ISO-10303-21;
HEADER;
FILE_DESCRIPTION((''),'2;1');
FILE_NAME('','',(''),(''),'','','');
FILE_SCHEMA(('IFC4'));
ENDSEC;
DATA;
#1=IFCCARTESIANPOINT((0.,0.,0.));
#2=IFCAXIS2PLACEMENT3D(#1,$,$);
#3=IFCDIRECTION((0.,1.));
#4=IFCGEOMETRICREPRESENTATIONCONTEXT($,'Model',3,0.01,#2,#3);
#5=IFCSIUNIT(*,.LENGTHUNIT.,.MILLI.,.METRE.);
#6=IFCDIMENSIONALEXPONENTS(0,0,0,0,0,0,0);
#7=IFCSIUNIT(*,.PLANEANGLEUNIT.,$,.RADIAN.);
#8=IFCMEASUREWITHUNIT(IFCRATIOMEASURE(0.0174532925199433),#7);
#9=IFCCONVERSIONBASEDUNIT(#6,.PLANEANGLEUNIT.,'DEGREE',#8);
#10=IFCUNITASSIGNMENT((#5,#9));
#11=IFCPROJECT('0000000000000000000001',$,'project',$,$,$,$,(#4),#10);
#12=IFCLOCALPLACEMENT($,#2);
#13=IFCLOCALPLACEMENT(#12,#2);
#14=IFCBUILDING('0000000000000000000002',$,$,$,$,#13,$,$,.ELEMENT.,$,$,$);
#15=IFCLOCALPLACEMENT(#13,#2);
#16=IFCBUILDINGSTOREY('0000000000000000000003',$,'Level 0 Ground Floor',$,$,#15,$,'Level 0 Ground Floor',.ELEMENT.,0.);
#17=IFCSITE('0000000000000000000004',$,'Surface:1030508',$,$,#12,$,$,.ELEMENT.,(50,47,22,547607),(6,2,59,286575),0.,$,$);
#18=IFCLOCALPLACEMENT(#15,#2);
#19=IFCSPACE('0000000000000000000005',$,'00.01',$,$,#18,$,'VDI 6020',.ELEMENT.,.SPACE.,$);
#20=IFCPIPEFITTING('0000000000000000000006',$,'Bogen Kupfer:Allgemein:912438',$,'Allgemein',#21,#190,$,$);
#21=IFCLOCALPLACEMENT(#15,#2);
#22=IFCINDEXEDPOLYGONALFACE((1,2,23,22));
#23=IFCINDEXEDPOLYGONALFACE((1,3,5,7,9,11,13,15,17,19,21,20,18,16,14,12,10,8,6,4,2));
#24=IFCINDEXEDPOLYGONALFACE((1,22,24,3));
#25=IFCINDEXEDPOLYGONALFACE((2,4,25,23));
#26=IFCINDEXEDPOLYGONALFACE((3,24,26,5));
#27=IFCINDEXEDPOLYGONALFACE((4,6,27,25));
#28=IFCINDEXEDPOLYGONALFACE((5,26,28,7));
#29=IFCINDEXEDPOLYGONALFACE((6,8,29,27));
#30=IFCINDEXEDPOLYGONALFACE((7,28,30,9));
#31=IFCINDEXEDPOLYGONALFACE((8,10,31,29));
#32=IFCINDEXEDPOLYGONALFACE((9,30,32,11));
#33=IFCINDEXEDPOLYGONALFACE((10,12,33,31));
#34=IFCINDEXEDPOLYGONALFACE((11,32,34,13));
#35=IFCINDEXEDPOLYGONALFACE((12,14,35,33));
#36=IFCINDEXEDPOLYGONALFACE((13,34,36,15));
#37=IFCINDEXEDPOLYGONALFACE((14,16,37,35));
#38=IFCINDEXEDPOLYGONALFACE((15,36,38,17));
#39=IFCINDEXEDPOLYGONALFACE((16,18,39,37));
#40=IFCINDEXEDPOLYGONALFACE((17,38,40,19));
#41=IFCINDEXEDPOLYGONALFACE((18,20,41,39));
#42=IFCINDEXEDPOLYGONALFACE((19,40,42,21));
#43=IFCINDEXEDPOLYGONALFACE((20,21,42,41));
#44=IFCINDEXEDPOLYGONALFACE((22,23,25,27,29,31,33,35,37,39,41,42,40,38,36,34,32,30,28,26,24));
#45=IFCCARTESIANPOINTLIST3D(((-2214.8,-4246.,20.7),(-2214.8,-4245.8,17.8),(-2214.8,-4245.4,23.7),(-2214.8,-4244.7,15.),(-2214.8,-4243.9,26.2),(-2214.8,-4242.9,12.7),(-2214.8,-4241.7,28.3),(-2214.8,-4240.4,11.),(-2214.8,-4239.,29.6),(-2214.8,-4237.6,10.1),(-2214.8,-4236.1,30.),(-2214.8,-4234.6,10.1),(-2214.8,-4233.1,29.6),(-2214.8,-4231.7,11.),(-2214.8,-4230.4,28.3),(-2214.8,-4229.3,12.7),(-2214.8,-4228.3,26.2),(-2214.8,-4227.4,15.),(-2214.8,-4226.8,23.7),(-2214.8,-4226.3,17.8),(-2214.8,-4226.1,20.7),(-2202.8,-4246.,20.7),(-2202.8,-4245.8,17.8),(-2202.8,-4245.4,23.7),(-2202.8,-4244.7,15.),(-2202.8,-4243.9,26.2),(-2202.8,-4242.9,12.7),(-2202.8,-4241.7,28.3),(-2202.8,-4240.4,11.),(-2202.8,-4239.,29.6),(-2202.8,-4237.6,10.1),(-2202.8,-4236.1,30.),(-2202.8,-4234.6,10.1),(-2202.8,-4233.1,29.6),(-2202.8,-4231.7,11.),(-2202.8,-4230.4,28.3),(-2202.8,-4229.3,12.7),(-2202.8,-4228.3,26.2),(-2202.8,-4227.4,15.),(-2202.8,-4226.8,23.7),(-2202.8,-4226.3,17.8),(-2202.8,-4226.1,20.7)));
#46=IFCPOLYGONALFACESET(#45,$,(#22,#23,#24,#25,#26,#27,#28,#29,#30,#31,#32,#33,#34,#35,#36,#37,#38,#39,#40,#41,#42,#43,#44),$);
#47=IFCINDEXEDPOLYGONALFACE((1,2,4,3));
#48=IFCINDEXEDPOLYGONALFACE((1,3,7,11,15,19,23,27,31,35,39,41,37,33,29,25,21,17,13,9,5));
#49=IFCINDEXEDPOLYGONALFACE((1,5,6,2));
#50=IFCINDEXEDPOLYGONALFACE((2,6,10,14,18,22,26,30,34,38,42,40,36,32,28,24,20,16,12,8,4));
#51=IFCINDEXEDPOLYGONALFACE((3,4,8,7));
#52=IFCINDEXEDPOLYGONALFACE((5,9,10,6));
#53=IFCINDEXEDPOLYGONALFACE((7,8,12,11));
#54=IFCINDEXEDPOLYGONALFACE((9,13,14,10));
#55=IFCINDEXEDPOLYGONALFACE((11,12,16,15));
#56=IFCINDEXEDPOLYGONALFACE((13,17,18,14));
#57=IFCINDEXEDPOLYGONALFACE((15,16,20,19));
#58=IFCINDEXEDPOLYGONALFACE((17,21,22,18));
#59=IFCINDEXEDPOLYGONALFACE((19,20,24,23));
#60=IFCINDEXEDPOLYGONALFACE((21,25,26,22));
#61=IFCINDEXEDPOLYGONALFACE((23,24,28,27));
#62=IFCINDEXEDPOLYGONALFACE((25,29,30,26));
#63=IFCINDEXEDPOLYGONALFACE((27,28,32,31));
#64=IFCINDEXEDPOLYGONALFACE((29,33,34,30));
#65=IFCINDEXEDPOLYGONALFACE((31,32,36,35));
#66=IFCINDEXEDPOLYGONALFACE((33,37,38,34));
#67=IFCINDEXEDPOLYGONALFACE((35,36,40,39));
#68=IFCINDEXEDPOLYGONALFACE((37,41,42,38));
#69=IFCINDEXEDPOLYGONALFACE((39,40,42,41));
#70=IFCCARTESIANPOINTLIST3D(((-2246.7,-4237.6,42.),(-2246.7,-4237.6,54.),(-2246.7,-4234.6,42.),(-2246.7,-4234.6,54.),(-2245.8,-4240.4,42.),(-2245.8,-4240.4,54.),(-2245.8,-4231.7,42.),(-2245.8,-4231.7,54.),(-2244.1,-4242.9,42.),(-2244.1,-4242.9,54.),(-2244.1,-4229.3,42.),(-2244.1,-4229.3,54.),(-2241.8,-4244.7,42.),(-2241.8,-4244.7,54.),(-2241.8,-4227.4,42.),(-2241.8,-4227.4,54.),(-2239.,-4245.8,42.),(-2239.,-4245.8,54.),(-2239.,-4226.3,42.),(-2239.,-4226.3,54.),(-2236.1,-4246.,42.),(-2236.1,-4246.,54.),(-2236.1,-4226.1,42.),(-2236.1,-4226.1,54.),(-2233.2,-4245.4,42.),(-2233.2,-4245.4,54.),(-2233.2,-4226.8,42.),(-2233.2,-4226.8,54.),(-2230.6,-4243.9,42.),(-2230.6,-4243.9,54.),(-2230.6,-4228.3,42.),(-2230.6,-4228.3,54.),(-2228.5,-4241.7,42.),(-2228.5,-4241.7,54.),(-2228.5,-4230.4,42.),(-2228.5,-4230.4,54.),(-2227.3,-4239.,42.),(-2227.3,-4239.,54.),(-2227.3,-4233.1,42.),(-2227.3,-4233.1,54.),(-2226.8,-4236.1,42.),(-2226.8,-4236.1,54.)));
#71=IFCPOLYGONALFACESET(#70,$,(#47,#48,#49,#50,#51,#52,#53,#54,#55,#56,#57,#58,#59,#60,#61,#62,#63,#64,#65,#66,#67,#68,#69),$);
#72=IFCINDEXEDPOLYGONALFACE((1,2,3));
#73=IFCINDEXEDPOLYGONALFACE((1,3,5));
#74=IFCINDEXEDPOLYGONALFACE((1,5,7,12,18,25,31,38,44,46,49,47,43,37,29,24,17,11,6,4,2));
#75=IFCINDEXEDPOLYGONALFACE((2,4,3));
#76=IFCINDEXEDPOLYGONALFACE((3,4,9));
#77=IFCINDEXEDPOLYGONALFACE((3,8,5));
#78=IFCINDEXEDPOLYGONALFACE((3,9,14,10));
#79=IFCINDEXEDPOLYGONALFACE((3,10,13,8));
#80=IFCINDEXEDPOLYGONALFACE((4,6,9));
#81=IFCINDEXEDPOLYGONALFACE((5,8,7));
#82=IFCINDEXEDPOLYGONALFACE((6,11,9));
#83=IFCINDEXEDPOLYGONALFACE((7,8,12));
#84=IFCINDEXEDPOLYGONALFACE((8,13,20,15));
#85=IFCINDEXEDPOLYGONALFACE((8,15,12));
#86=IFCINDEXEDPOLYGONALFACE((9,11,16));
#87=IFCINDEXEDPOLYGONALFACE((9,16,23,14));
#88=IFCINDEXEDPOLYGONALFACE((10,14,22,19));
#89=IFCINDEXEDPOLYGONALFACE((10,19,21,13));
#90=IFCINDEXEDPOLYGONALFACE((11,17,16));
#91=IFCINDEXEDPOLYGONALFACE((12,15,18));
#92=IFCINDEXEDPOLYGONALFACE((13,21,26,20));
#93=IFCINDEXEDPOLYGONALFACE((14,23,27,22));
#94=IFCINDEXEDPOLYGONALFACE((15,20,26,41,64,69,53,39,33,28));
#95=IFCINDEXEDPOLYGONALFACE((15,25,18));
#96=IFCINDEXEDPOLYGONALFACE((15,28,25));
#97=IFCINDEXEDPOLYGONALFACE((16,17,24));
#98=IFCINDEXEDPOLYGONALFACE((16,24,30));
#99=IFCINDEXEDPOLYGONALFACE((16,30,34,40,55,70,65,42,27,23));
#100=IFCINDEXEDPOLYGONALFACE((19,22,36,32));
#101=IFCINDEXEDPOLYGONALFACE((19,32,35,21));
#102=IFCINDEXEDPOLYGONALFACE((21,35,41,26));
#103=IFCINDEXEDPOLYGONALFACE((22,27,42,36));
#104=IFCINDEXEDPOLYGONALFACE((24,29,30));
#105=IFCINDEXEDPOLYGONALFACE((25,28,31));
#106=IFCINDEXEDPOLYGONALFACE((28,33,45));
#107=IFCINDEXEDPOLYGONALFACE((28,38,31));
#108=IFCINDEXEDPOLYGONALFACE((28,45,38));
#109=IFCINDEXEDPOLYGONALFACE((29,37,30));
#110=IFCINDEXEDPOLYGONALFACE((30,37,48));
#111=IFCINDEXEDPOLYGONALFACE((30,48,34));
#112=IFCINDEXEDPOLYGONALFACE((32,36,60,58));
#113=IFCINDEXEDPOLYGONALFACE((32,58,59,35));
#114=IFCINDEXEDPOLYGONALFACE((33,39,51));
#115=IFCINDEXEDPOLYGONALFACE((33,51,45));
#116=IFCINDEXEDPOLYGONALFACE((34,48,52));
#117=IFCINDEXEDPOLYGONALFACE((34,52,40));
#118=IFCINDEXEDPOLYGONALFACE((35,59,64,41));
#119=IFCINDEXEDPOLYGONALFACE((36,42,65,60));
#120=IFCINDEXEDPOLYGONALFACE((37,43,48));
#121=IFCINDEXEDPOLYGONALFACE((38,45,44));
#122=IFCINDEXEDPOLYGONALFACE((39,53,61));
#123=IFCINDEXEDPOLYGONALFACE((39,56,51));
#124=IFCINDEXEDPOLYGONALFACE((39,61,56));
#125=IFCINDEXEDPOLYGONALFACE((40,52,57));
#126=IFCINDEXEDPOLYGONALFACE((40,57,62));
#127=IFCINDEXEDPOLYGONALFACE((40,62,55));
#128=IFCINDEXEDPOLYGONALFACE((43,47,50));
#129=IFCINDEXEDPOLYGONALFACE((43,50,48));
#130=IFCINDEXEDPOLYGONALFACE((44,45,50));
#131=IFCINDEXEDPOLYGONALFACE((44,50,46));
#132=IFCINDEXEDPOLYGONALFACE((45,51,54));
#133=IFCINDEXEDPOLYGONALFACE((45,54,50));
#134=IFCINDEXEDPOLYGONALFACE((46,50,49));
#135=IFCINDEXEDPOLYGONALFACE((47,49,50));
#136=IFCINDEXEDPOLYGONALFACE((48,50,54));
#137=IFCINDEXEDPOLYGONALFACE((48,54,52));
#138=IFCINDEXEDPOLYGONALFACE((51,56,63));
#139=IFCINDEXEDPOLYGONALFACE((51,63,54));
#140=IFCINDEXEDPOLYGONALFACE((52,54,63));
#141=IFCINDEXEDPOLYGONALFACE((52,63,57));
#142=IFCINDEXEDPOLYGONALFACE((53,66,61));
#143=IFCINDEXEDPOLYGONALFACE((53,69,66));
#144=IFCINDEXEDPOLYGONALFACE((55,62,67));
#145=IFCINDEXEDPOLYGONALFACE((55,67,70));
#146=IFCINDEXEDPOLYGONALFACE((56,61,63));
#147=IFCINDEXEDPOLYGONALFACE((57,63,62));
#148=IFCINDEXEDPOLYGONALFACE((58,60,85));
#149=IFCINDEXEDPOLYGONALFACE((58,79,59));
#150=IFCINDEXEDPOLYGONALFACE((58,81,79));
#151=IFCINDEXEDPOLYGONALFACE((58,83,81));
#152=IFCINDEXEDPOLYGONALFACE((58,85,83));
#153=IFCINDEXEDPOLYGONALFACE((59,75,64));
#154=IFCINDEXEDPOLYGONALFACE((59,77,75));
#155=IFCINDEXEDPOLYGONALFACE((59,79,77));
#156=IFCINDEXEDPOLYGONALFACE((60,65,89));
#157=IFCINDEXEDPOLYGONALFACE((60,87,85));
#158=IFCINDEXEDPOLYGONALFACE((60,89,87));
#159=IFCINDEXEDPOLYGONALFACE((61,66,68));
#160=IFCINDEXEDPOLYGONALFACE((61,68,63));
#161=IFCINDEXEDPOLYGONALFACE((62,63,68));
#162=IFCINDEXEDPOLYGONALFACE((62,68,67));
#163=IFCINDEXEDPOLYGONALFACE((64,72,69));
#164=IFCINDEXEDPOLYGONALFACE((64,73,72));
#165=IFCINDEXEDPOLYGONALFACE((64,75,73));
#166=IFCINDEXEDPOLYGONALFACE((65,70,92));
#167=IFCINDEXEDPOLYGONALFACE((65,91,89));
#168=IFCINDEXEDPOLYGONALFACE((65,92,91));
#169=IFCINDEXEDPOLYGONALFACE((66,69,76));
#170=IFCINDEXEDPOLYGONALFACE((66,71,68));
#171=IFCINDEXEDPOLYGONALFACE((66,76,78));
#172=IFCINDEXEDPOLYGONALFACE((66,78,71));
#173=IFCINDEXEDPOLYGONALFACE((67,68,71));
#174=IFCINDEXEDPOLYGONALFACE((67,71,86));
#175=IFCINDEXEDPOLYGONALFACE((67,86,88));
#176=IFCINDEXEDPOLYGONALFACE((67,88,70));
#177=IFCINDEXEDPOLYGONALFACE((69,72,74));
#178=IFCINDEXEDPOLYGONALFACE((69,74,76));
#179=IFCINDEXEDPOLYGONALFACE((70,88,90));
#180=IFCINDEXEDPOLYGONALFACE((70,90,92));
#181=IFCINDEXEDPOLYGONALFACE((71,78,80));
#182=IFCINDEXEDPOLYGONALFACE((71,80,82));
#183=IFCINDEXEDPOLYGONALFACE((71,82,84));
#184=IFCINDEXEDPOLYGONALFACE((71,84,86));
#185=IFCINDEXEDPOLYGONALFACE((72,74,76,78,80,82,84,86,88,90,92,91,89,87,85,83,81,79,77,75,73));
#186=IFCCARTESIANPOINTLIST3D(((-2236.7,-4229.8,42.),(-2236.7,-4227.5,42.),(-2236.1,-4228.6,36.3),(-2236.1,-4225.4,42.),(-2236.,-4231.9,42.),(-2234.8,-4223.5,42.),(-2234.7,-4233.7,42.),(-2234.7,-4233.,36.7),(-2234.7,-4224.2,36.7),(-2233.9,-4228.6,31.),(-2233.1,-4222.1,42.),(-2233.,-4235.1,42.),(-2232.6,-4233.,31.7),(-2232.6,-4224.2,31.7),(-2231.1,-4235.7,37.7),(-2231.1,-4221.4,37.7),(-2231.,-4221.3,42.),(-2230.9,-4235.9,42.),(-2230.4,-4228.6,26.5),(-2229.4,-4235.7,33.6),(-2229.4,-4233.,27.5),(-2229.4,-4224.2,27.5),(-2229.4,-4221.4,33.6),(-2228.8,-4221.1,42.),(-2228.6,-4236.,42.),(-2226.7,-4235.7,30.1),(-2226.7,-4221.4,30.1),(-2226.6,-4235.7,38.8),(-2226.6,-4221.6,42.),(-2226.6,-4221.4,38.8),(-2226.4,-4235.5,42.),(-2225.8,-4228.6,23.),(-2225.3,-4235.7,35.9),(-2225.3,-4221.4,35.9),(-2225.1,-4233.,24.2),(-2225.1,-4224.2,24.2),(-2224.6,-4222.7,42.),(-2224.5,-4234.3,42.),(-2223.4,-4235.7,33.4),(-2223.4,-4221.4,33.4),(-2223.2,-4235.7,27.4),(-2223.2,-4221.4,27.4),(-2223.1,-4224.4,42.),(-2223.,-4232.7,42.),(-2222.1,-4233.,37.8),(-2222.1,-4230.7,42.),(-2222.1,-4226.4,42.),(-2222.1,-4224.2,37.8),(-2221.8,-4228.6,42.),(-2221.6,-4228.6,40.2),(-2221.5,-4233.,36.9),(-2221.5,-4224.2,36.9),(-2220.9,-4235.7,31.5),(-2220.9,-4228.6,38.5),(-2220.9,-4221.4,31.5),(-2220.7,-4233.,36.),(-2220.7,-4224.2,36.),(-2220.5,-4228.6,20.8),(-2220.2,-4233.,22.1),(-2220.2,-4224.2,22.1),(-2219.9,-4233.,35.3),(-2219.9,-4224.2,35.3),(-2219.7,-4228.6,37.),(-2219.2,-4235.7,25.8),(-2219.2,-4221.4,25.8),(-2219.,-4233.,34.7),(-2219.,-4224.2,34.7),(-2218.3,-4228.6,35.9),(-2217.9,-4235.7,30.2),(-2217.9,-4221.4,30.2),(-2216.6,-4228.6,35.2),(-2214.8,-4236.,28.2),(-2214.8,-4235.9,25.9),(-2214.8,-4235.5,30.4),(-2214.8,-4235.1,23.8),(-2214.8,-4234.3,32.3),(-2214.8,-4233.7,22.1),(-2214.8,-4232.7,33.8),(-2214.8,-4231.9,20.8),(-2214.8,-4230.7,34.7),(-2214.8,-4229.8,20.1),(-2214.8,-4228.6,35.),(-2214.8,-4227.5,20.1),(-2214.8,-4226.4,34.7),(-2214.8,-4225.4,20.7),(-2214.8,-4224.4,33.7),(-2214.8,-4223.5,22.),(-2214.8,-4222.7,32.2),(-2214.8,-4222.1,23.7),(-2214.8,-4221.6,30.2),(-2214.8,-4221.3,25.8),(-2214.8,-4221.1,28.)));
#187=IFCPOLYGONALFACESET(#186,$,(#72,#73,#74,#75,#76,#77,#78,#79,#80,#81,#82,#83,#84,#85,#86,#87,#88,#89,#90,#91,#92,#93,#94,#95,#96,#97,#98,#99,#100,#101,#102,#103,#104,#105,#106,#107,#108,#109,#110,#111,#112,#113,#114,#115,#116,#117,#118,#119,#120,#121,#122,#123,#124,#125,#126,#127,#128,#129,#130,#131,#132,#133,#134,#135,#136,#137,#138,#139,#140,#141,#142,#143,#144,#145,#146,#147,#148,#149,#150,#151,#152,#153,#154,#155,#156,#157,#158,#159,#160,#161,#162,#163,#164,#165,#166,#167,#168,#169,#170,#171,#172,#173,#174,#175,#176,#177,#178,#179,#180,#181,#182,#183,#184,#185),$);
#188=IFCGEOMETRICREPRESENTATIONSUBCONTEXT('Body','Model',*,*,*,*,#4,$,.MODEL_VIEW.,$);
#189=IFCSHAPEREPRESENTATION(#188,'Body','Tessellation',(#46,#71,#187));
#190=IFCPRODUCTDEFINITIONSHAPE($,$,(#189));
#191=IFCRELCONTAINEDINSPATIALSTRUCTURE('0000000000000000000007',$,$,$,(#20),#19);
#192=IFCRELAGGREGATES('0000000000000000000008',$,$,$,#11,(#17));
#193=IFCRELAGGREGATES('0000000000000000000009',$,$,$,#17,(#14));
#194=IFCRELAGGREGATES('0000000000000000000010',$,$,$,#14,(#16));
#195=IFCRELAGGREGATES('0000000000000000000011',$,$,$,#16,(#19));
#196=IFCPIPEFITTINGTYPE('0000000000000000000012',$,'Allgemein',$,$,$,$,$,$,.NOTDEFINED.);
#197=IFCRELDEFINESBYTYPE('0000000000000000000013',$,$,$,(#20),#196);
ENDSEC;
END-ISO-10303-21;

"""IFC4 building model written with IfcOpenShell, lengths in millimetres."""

from ifc_helpers import new_model, entity, si_unit, converted_unit, direction, frame, frame_2d, origin, place, context, subcontext, project, spatial, circle, extrude, source, transform, mapped, type_object, type_shapes, element, save


model = new_model("IFC4")

# Units and contexts
model_context = context("Model", 3, precision=0.01, world=origin(), true_north=direction((0.0, 1.0)))
body_context = subcontext(model_context, "Body", "Model", "MODEL_VIEW")
ifc_project = project(units=[si_unit("LENGTHUNIT", "METRE", prefix="MILLI"), converted_unit("PLANEANGLEUNIT", "DEGREE", entity("IfcRatioMeasure", 0.0174532925199433), si_unit("PLANEANGLEUNIT", "RADIAN"), dimensions=[0, 0, 0, 0, 0, 0, 0])], contexts=[model_context])

# Site, building, storey
site_placement = place(None, origin())
site = spatial("IfcSite", under=ifc_project, at=site_placement, Name="Surface:1030508", CompositionType="ELEMENT", RefLatitude=(50, 47, 22, 547607), RefLongitude=(6, 2, 59, 286575), RefElevation=0.0)
building_placement = place(site_placement, origin())
building = spatial("IfcBuilding", under=site, at=building_placement, CompositionType="ELEMENT")
storey_placement = place(building_placement, origin())
storey = spatial("IfcBuildingStorey", under=building, at=storey_placement, Name="Level 0 Ground Floor", LongName="Level 0 Ground Floor", CompositionType="ELEMENT", Elevation=0.0)

# Shared definitions
pipe_fitting_type_1 = type_object("IfcPipeFittingType", Name="Allgemein", PredefinedType="NOTDEFINED")
ifc_direction_1 = entity("IfcDirection", [0.0, 0.0, -1.0])
trimmed_curve_1 = entity("IfcTrimmedCurve", entity("IfcCircle", entity("IfcAxis2Placement2D", entity("IfcCartesianPoint", [-14.5, 0.0]), entity("IfcDirection", [0.0, 1.0])), 14.5), [entity("IfcParameterValue", 270.0)], [entity("IfcParameterValue", 0.0)], True, "PARAMETER")
shared_shape_1 = source(origin(), body_context, "Body", "SolidModel", [
    extrude(circle(Radius=10.0, at=frame_2d((0.0, 0.0), x_axis=(1.0, 0.0))), frame((0.0, 22.0, 0.0), z_axis=(0.0, 1.0, 0.0), x_axis=(-1.0, 0.0, 0.0)), (0.0, 0.0, 1.0), 12.0),
    extrude(circle(Radius=10.0, at=frame_2d((0.0, 0.0), x_axis=(1.0, 0.0))), frame((-34.0, 0.0, 0.0), z_axis=(1.0, 0.0, 0.0), x_axis=(0.0, 1.0, 0.0)), (0.0, 0.0, 1.0), 12.0),
    entity("IfcSurfaceCurveSweptAreaSolid", entity("IfcCircleProfileDef", "AREA", None, entity("IfcAxis2Placement2D", entity("IfcCartesianPoint", [0.0, 7.5]), entity("IfcDirection", [1.0, 0.0])), 7.5), entity("IfcAxis2Placement3D", entity("IfcCartesianPoint", [-7.5, 22.0, 0.0]), ifc_direction_1, entity("IfcDirection", [1.0, 0.0, 0.0])), trimmed_curve_1, 0.0, 90.0, entity("IfcSurfaceOfLinearExtrusion", entity("IfcArbitraryOpenProfileDef", "CURVE", None, trimmed_curve_1), entity("IfcAxis2Placement3D", entity("IfcCartesianPoint", [0.0, 0.0, -304.8])), ifc_direction_1, 1.0)),
])
type_shapes(pipe_fitting_type_1, [shared_shape_1])

# Shared definitions
space_placement = place(storey_placement, origin())
space = spatial("IfcSpace", under=storey, at=space_placement, Name="00.01", LongName="VDI 6020", CompositionType="ELEMENT", PredefinedType="SPACE")

# Pipe fitting
for number, where, z_axis, x_axis, name in (
    (1, (-2236.8, -4236.1, 20.0), (0.0, -1.0, 0.0), (0.0, 0.0, -1.0), "Bogen Kupfer:Allgemein:912438"),
):
    element("IfcPipeFitting", number, at=place(space_placement, frame(where, z_axis=z_axis, x_axis=x_axis)), inside=space, type_object=pipe_fitting_type_1, Name=name, ObjectType="Allgemein", context=body_context, shape_type="MappedRepresentation", body=[
        mapped(shared_shape_1, transform((0.0, 0.0, 0.0), scale=1.0)),
    ])

save(model, "model.ifc")
